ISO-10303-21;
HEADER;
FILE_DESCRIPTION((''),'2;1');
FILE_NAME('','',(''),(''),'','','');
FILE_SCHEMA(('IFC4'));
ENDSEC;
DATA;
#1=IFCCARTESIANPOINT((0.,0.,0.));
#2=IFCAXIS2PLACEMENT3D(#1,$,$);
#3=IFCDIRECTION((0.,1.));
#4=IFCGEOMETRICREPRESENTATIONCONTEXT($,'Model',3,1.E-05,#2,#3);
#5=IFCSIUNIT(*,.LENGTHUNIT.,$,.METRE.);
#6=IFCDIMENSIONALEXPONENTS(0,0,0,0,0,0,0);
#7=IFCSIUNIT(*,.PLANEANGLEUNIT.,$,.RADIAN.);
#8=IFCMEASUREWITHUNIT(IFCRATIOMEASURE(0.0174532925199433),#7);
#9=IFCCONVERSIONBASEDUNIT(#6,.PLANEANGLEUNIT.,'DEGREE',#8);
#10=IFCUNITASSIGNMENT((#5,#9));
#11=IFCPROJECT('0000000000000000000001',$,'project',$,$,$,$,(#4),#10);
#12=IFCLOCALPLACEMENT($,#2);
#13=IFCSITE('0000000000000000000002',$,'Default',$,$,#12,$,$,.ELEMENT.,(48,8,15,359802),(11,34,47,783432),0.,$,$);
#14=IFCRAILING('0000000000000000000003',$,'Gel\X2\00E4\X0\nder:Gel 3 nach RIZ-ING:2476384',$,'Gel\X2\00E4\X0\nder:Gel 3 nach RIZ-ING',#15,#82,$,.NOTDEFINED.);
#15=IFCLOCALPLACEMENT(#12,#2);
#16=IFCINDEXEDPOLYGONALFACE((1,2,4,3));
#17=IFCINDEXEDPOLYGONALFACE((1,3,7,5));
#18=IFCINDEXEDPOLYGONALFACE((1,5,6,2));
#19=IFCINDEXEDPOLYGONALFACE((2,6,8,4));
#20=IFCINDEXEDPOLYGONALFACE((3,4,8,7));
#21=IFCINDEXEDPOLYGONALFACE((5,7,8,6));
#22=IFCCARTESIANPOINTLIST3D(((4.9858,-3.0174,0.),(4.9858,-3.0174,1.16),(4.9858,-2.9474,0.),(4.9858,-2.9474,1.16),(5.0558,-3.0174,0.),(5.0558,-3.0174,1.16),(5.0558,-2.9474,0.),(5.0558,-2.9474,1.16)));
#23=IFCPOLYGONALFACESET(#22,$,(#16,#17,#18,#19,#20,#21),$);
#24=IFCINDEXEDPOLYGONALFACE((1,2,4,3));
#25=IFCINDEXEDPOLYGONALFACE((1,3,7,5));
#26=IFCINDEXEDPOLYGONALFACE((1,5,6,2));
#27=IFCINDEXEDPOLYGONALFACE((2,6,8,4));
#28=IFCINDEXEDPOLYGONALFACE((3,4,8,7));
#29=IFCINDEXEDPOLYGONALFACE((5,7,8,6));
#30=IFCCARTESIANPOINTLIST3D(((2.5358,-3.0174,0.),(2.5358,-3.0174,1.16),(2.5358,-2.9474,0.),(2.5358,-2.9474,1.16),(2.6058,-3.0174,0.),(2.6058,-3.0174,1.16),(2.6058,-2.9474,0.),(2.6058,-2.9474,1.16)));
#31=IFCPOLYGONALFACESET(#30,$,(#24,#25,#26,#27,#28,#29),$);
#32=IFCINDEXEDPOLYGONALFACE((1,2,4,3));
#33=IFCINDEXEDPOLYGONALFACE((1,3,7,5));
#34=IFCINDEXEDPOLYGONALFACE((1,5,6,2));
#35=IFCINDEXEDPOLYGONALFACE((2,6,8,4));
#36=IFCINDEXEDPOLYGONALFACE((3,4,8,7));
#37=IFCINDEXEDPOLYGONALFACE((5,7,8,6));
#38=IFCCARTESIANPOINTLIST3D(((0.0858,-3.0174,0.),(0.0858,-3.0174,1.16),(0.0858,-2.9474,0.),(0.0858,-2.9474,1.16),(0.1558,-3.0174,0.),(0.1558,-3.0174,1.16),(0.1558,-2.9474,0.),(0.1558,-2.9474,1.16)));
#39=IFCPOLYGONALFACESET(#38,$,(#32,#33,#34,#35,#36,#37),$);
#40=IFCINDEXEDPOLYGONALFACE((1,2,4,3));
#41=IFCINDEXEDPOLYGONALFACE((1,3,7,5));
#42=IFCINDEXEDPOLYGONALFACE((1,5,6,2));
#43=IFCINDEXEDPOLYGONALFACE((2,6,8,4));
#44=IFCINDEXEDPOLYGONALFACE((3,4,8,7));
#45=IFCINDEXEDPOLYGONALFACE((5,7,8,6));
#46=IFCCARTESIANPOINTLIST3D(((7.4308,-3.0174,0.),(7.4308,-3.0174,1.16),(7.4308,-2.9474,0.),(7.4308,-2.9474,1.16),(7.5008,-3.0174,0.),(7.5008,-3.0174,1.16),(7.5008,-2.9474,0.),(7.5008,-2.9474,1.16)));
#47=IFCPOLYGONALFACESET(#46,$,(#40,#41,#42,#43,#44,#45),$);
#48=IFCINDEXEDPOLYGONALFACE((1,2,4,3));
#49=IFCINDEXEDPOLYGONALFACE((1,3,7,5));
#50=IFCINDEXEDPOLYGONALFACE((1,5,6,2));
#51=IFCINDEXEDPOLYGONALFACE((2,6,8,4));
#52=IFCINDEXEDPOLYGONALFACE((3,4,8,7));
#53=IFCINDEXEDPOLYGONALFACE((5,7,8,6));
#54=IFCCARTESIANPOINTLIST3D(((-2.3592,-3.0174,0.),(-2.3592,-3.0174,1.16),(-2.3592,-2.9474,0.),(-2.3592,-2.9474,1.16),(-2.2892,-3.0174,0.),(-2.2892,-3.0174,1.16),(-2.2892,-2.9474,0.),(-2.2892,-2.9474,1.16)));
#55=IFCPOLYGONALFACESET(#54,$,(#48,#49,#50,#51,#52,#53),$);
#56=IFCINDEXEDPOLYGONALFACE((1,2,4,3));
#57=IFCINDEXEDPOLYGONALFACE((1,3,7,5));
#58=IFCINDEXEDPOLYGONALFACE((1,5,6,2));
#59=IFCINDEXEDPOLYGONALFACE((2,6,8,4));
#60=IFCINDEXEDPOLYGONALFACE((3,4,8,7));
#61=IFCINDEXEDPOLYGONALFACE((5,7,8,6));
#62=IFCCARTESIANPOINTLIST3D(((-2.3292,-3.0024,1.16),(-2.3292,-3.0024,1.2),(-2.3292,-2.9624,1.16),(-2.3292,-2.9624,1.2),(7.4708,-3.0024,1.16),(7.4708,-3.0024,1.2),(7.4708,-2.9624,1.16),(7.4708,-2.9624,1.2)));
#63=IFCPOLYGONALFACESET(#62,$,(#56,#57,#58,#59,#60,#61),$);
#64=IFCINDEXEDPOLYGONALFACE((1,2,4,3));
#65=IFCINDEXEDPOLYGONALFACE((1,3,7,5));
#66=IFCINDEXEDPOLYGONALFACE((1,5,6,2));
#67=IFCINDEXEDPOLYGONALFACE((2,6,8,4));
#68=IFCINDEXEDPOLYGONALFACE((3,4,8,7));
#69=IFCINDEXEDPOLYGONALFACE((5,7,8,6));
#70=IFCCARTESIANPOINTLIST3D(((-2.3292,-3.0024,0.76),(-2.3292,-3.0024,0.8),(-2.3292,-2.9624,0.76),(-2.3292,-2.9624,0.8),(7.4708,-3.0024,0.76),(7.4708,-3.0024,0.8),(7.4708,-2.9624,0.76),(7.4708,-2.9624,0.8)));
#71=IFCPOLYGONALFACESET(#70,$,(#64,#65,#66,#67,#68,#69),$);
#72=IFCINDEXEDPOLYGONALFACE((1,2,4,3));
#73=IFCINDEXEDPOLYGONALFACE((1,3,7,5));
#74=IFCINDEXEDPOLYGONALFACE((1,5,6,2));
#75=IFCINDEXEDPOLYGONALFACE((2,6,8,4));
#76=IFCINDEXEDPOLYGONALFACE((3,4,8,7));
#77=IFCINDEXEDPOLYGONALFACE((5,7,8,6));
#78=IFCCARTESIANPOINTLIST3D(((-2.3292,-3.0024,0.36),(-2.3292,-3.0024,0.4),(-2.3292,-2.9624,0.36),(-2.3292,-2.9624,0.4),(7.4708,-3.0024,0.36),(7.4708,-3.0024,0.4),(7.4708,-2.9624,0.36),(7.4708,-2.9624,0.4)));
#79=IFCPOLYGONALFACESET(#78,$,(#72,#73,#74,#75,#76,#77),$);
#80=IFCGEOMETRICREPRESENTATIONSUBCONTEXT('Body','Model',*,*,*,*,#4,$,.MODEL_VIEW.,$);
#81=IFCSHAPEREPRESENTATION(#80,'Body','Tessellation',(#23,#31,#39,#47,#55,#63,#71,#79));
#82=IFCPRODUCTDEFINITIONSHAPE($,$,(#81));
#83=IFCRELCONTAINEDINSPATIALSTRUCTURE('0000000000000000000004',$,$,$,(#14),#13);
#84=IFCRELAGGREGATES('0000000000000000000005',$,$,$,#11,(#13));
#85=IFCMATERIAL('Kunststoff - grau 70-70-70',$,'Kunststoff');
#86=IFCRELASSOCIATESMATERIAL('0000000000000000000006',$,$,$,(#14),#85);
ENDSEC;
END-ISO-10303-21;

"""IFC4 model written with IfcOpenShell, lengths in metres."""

from ifc_helpers import new_model, entity, si_unit, converted_unit, direction, frame, frame_2d, origin, place, context, subcontext, project, spatial, rectangle, extrude, material, element, save


model = new_model("IFC4")

# Units and contexts
model_context = context("Model", 3, precision=1e-05, world=origin(), true_north=direction((0.0, 1.0)))
body_context = subcontext(model_context, "Body", "Model", "MODEL_VIEW")
ifc_project = project(units=[si_unit("LENGTHUNIT", "METRE"), converted_unit("PLANEANGLEUNIT", "DEGREE", entity("IfcRatioMeasure", 0.0174532925199433), si_unit("PLANEANGLEUNIT", "RADIAN"), dimensions=[0, 0, 0, 0, 0, 0, 0])], contexts=[model_context])

# Site
site_placement = place(None, origin())
site = spatial("IfcSite", under=ifc_project, at=site_placement, Name="Default", CompositionType="ELEMENT", RefLatitude=(48, 8, 15, 359802), RefLongitude=(11, 34, 47, 783432), RefElevation=0.0)

# Railing
ifc_material = material(Name="Kunststoff - grau 70-70-70", Category="Kunststoff")
railing_placement = place(site_placement, frame((-2.3592, -3.0174, 0.0)))
element("IfcRailing", 1, at=railing_placement, inside=site, material=ifc_material, Name="Geländer:Gel 3 nach RIZ-ING:2476384", ObjectType="Geländer:Gel 3 nach RIZ-ING", PredefinedType="NOTDEFINED", context=body_context, shape_type="SweptSolid", body=[
    extrude(rectangle(XDim=0.07, YDim=0.07, at=frame_2d((0.0, 0.0), x_axis=(1.0, 0.0))), frame((7.38, 0.035, 0.0)), (0.0, 0.0, 1.0), 1.16),
    extrude(rectangle(XDim=0.07, YDim=0.07, at=frame_2d((0.0, 0.0), x_axis=(1.0, 0.0))), frame((4.93, 0.035, 0.0)), (0.0, 0.0, 1.0), 1.16),
    extrude(rectangle(XDim=0.07, YDim=0.07, at=frame_2d((0.0, 0.0), x_axis=(1.0, 0.0))), frame((2.48, 0.035, 0.0)), (0.0, 0.0, 1.0), 1.16),
    extrude(rectangle(XDim=0.07, YDim=0.07, at=frame_2d((0.0, 0.0), x_axis=(1.0, 0.0))), frame((9.825, 0.035, 0.0)), (0.0, 0.0, 1.0), 1.16),
    extrude(rectangle(XDim=0.07, YDim=0.07, at=frame_2d((0.0, 0.0), x_axis=(1.0, 0.0))), frame((0.035, 0.035, 0.0)), (0.0, 0.0, 1.0), 1.16),
    extrude(rectangle(XDim=9.8, YDim=0.04, at=frame_2d((0.0, 0.0), x_axis=(1.0, 0.0))), frame((4.93, 0.035, 1.16)), (0.0, 0.0, 1.0), 0.04),
    extrude(rectangle(XDim=9.8, YDim=0.04, at=frame_2d((0.0, 0.0), x_axis=(1.0, 0.0))), frame((4.93, 0.035, 0.76)), (0.0, 0.0, 1.0), 0.04),
    extrude(rectangle(XDim=9.8, YDim=0.04, at=frame_2d((0.0, 0.0), x_axis=(1.0, 0.0))), frame((4.93, 0.035, 0.36)), (0.0, 0.0, 1.0), 0.04),
])

save(model, "model.ifc")
